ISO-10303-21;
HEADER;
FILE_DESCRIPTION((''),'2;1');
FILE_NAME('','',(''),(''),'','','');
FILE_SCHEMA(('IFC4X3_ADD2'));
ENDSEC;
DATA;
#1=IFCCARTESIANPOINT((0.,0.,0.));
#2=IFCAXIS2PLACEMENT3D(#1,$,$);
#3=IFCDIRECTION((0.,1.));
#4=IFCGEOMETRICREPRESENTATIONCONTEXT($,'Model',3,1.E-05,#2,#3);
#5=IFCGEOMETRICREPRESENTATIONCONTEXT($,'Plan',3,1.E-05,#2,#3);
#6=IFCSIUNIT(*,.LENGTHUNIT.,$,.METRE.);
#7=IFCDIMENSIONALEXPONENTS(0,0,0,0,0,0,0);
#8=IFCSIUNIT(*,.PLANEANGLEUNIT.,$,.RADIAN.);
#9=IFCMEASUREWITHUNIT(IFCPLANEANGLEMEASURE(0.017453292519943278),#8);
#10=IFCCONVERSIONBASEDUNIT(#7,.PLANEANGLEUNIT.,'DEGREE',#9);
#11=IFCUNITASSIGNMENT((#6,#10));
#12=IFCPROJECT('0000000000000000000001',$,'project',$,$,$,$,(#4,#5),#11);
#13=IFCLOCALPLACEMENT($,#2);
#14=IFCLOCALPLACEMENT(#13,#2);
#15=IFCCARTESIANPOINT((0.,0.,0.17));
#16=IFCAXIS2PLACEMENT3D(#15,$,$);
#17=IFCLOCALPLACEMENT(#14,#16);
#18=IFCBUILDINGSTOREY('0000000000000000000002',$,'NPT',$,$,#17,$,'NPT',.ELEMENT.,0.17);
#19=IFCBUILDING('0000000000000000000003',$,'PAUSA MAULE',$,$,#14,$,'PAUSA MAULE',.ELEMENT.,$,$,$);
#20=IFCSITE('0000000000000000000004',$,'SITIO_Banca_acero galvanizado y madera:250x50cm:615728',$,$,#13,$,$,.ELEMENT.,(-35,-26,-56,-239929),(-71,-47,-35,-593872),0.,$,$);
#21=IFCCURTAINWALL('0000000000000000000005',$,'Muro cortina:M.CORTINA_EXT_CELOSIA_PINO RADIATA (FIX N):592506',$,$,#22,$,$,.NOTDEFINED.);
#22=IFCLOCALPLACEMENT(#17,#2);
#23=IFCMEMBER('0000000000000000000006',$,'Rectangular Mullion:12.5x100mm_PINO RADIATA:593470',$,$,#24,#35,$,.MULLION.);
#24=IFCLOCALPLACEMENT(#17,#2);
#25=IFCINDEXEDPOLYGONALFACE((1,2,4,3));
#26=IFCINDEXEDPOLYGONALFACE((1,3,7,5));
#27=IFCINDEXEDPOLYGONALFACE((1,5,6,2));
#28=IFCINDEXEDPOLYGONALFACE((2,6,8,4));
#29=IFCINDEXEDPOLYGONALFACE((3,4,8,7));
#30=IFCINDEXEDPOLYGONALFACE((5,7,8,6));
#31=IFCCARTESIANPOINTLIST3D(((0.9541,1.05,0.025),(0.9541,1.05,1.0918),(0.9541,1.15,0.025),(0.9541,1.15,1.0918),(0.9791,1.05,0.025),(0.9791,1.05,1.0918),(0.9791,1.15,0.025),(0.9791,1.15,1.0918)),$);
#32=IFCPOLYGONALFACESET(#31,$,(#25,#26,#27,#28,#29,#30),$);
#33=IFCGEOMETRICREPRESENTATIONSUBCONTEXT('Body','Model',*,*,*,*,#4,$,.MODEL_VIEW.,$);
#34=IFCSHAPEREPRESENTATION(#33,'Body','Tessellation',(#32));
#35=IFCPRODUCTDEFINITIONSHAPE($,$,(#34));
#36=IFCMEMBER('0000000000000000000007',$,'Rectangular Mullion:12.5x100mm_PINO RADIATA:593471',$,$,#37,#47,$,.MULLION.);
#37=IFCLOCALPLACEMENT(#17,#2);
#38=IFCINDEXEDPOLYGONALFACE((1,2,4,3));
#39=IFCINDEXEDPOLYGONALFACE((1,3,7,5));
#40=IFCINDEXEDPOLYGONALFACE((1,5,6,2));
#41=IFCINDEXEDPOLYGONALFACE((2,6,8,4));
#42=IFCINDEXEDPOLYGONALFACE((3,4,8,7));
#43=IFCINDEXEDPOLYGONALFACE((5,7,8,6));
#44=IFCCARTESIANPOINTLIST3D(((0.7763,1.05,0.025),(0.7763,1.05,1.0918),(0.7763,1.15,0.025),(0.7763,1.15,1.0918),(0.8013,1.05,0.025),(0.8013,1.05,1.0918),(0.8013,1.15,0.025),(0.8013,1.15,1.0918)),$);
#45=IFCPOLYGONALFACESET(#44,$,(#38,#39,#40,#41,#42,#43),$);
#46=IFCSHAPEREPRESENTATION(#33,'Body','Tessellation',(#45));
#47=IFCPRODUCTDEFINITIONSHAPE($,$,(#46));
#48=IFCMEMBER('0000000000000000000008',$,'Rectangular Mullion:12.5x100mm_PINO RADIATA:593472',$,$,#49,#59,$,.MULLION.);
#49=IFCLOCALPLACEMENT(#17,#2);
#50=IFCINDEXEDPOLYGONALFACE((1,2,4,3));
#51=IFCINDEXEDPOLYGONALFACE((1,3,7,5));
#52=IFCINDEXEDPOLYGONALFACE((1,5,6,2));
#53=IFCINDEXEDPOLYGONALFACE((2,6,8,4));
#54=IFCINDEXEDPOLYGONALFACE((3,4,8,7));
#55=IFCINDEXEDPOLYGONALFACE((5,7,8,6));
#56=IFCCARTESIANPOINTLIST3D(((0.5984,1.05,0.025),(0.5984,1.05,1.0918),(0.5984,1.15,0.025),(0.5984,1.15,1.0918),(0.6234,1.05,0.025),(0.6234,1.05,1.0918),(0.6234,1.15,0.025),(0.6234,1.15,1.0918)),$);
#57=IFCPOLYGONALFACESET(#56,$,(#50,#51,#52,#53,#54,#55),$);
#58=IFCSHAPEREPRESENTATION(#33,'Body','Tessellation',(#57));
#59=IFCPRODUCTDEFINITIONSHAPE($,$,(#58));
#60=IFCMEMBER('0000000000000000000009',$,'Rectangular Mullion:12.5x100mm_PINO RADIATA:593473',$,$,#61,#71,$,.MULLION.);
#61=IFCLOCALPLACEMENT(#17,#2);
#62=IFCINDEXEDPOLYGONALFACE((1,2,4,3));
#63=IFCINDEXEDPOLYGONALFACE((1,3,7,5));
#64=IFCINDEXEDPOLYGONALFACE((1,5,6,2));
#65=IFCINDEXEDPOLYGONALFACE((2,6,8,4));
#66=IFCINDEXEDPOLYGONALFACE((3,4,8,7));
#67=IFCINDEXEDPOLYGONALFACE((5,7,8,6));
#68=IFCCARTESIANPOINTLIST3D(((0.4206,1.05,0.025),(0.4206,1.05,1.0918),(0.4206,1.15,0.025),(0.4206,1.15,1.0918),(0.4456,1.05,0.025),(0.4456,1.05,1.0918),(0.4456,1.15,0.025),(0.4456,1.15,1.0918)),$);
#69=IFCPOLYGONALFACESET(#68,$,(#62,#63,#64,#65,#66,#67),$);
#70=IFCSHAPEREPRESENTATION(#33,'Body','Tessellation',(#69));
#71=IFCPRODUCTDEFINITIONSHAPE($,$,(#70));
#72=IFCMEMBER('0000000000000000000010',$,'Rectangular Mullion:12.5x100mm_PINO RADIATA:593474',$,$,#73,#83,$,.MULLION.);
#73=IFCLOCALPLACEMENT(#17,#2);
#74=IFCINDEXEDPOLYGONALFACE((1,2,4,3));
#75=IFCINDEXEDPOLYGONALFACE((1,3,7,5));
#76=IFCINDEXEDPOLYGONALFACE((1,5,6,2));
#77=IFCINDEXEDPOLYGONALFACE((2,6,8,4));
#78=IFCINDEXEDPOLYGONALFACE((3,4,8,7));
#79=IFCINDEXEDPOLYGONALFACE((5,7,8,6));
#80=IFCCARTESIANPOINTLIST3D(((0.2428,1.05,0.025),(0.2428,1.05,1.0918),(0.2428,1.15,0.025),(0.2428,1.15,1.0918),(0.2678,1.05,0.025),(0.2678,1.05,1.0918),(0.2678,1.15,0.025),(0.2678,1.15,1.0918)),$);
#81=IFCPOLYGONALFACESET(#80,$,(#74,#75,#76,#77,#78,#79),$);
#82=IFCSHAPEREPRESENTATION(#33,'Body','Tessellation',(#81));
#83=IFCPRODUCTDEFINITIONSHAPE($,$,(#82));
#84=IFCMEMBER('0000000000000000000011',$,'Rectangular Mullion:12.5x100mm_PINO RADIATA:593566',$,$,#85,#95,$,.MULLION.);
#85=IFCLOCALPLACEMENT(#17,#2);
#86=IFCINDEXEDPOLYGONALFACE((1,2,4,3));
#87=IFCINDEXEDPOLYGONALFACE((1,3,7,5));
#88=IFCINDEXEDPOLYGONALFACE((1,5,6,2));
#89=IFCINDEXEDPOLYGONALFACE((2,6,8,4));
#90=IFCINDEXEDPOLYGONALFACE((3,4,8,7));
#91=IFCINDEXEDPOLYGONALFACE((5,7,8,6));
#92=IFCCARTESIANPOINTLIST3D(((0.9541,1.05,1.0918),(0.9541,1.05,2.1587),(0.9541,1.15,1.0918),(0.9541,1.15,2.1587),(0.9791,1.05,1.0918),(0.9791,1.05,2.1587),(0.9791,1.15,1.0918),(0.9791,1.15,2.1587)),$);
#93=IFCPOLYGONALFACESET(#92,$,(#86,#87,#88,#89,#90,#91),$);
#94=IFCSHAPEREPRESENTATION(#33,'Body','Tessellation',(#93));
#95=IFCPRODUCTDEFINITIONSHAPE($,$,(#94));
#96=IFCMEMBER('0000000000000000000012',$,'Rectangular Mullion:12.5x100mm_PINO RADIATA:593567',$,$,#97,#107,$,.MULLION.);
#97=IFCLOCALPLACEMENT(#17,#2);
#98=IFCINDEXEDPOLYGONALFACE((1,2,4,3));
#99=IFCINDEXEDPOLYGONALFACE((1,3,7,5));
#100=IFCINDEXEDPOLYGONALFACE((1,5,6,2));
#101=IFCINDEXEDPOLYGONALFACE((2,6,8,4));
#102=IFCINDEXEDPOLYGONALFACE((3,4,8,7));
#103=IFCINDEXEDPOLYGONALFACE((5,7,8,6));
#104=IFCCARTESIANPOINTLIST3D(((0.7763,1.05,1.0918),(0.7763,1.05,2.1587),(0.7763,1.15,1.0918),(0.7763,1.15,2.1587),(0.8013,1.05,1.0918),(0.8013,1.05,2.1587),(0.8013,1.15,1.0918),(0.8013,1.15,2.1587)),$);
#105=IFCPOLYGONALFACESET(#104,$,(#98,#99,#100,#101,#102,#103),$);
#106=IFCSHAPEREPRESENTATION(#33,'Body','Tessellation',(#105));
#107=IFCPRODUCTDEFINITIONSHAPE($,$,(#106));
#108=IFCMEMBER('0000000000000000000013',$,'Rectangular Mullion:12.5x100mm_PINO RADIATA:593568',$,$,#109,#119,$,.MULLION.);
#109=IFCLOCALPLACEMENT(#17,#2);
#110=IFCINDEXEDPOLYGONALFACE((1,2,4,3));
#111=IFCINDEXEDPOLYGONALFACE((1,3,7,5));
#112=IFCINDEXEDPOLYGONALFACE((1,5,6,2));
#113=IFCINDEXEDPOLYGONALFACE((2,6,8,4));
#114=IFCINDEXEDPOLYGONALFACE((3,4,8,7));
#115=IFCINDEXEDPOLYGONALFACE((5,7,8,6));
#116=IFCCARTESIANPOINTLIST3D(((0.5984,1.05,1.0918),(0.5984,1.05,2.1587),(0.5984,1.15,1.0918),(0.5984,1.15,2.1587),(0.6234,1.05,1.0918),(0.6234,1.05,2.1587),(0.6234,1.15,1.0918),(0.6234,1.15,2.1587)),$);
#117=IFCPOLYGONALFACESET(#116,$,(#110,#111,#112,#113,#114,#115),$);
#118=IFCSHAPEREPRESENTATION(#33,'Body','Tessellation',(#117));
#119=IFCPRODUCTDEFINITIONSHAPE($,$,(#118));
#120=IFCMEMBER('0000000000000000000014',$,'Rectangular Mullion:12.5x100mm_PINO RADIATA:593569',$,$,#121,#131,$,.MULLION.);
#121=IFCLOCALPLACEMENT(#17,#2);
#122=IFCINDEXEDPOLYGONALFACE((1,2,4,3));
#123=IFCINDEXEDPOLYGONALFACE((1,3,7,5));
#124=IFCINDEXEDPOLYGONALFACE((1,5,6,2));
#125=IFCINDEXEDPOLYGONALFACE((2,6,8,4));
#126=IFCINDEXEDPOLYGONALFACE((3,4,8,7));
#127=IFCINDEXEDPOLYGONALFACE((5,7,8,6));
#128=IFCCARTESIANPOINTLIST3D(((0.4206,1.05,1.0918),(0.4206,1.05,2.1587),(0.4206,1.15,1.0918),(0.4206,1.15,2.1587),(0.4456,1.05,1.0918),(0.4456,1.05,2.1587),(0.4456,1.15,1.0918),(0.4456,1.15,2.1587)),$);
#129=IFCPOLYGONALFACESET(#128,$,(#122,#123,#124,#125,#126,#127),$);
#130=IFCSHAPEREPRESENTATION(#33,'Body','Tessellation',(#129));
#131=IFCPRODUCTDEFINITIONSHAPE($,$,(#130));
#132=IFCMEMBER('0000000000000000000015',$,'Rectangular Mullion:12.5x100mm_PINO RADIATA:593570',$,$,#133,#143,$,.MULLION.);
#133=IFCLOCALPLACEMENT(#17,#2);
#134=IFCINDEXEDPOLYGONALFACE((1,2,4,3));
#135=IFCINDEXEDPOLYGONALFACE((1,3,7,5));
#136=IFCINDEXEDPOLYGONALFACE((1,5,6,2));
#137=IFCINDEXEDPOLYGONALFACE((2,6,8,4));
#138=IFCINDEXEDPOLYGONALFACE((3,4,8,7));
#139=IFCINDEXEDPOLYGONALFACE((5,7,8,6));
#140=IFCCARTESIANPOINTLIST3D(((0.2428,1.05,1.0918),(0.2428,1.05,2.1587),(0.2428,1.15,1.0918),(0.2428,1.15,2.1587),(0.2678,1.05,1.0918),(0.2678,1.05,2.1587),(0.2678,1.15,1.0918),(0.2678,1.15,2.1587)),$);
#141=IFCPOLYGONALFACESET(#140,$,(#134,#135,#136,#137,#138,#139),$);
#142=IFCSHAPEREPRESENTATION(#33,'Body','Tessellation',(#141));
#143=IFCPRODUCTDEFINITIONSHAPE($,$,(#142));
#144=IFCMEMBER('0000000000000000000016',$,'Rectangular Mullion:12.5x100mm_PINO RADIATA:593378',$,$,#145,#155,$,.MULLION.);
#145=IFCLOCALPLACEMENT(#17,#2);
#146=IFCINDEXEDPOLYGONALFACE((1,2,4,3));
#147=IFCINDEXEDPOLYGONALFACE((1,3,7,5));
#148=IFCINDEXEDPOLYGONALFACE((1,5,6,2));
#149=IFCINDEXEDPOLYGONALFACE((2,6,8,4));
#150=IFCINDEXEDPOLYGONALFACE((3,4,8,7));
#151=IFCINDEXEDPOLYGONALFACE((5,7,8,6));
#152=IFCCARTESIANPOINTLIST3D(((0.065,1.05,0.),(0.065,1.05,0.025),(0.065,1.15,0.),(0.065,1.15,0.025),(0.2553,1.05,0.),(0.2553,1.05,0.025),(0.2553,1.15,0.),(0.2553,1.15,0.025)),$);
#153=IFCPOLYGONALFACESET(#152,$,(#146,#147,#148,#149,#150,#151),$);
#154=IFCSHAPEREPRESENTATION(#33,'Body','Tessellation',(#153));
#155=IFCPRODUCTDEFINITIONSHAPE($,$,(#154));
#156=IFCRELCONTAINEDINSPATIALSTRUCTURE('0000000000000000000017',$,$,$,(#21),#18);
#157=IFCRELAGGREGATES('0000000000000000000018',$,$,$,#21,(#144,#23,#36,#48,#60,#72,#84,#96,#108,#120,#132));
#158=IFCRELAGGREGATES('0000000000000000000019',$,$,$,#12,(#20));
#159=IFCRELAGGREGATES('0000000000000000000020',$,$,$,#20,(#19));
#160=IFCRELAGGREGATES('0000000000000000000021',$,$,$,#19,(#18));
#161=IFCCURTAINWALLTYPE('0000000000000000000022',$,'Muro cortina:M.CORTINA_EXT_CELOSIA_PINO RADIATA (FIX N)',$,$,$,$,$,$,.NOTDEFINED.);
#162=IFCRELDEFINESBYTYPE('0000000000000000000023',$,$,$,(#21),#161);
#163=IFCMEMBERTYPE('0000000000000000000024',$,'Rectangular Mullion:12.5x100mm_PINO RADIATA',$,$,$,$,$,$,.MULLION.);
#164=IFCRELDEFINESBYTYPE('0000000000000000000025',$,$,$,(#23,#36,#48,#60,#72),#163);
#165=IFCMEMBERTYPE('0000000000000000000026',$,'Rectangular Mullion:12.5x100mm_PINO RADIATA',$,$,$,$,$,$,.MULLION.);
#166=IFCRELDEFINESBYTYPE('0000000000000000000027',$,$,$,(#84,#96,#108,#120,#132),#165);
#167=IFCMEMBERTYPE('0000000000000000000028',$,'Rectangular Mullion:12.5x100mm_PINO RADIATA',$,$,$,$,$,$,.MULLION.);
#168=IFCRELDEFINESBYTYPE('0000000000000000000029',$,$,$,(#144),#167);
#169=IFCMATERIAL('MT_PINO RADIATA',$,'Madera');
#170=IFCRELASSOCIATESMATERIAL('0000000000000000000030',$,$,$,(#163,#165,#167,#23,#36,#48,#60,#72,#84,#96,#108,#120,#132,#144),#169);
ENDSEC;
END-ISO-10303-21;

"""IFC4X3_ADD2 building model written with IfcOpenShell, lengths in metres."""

from ifc_helpers import new_model, entity, si_unit, converted_unit, direction, frame, frame_2d, origin, origin_2d_with_axis, place, context, subcontext, project, spatial, rectangle, extrude, source, transform, mapped, material, material_profile, profile_set, profile_usage, type_object, type_shapes, element, aggregate, save


model = new_model("IFC4X3_ADD2")

# Units and contexts
model_context = context("Model", 3, precision=1e-05, world=origin(), true_north=direction((0.0, 1.0)))
plan_context = context("Plan", 3, precision=1e-05, world=origin(), true_north=direction((0.0, 1.0)))
body_context = subcontext(model_context, "Body", "Model", "MODEL_VIEW")
ifc_project = project(units=[si_unit("LENGTHUNIT", "METRE"), converted_unit("PLANEANGLEUNIT", "DEGREE", entity("IfcPlaneAngleMeasure", 0.017453292519943278), si_unit("PLANEANGLEUNIT", "RADIAN"), dimensions=[0, 0, 0, 0, 0, 0, 0])], contexts=[model_context, plan_context])

# Site, building, storey
site_placement = place(None, origin())
site = spatial("IfcSite", under=ifc_project, at=site_placement, Name="SITIO_Banca_acero galvanizado y madera:250x50cm:615728", CompositionType="ELEMENT", RefLatitude=(-35, -26, -56, -239929), RefLongitude=(-71, -47, -35, -593872), RefElevation=0.0)
building_placement = place(site_placement, origin())
building = spatial("IfcBuilding", under=site, at=building_placement, Name="PAUSA MAULE", LongName="PAUSA MAULE", CompositionType="ELEMENT")
storey_placement = place(building_placement, frame((0.0, 0.0, 0.17)))
storey = spatial("IfcBuildingStorey", under=building, at=storey_placement, Name="NPT", LongName="NPT", CompositionType="ELEMENT", Elevation=0.17)

# Curtain wall, members
curtain_wall_type = type_object("IfcCurtainWallType", Name="Muro cortina:M.CORTINA_EXT_CELOSIA_PINO RADIATA (FIX N)", PredefinedType="NOTDEFINED")
curtain_wall_placement = place(storey_placement, frame((0.0, 0.0, -0.17)))
curtain_wall = element("IfcCurtainWall", 1, at=curtain_wall_placement, inside=storey, type_object=curtain_wall_type, Name="Muro cortina:M.CORTINA_EXT_CELOSIA_PINO RADIATA (FIX N):592506", PredefinedType="NOTDEFINED")
ifc_material_1 = material(Name="MT_PINO RADIATA", Category="Madera")
ifc_material_profile = material_profile(ifc_material_1, rectangle(XDim=0.025, YDim=0.1, at=frame_2d((0.0, 0.0), x_axis=(1.0, 0.0))), Name="12.5x100mm_PINO RADIATA")
ifc_profile_set = profile_set([ifc_material_profile], Name="12.5x100mm_PINO RADIATA")
ifc_profile_usage = profile_usage(ifc_profile_set)
member_type_1 = type_object("IfcMemberType", Name="Rectangular Mullion:12.5x100mm_PINO RADIATA", PredefinedType="MULLION", material=ifc_profile_set)
shared_shape_1 = source(origin(), body_context, "Body", "SweptSolid", [
    extrude(rectangle(XDim=0.025, YDim=0.1, at=origin_2d_with_axis()), frame((0.0, 0.0, -1.0668), z_axis=(0.0, 0.0, 1.0), x_axis=(-1.0, 0.0, 0.0)), (0.0, 0.0, 1.0), 1.0668),
])
type_shapes(member_type_1, [shared_shape_1])
member_1_placement = place(curtain_wall_placement, frame((0.9666, 1.1, 0.195), z_axis=(0.0, 0.0, -1.0), x_axis=(-1.0, 0.0, 0.0)))
member_1 = element("IfcMember", 2, at=member_1_placement, type_object=member_type_1, material=ifc_profile_usage, Name="Rectangular Mullion:12.5x100mm_PINO RADIATA:593470", PredefinedType="MULLION", context=body_context, shape_type="MappedRepresentation", body=[
    mapped(shared_shape_1, transform((0.0, 0.0, 0.0), scale=1.0)),
])
member_2_placement = place(curtain_wall_placement, frame((0.7888, 1.1, 0.195), z_axis=(0.0, 0.0, -1.0), x_axis=(-1.0, 0.0, 0.0)))
member_2 = element("IfcMember", 3, at=member_2_placement, type_object=member_type_1, material=ifc_profile_usage, Name="Rectangular Mullion:12.5x100mm_PINO RADIATA:593471", PredefinedType="MULLION", context=body_context, shape_type="MappedRepresentation", body=[
    mapped(shared_shape_1, transform((0.0, 0.0, 0.0), scale=1.0)),
])
member_3_placement = place(curtain_wall_placement, frame((0.6109, 1.1, 0.195), z_axis=(0.0, 0.0, -1.0), x_axis=(-1.0, 0.0, 0.0)))
member_3 = element("IfcMember", 4, at=member_3_placement, type_object=member_type_1, material=ifc_profile_usage, Name="Rectangular Mullion:12.5x100mm_PINO RADIATA:593472", PredefinedType="MULLION", context=body_context, shape_type="MappedRepresentation", body=[
    mapped(shared_shape_1, transform((0.0, 0.0, 0.0), scale=1.0)),
])
member_4_placement = place(curtain_wall_placement, frame((0.4331, 1.1, 0.195), z_axis=(0.0, 0.0, -1.0), x_axis=(-1.0, 0.0, 0.0)))
member_4 = element("IfcMember", 5, at=member_4_placement, type_object=member_type_1, material=ifc_profile_usage, Name="Rectangular Mullion:12.5x100mm_PINO RADIATA:593473", PredefinedType="MULLION", context=body_context, shape_type="MappedRepresentation", body=[
    mapped(shared_shape_1, transform((0.0, 0.0, 0.0), scale=1.0)),
])
member_5_placement = place(curtain_wall_placement, frame((0.2553, 1.1, 0.195), z_axis=(0.0, 0.0, -1.0), x_axis=(-1.0, 0.0, 0.0)))
member_5 = element("IfcMember", 6, at=member_5_placement, type_object=member_type_1, material=ifc_profile_usage, Name="Rectangular Mullion:12.5x100mm_PINO RADIATA:593474", PredefinedType="MULLION", context=body_context, shape_type="MappedRepresentation", body=[
    mapped(shared_shape_1, transform((0.0, 0.0, 0.0), scale=1.0)),
])
member_type_2 = type_object("IfcMemberType", Name="Rectangular Mullion:12.5x100mm_PINO RADIATA", PredefinedType="MULLION", material=ifc_profile_set)
shared_shape_2 = source(origin(), body_context, "Body", "SweptSolid", [
    extrude(rectangle(XDim=0.025, YDim=0.1, at=origin_2d_with_axis()), frame((0.0, 0.0, -1.0668), z_axis=(0.0, 0.0, 1.0), x_axis=(-1.0, 0.0, 0.0)), (0.0, 0.0, 1.0), 1.0668),
])
type_shapes(member_type_2, [shared_shape_2])
member_6_placement = place(curtain_wall_placement, frame((0.9666, 1.1, 1.2618), z_axis=(0.0, 0.0, -1.0), x_axis=(-1.0, 0.0, 0.0)))
member_6 = element("IfcMember", 7, at=member_6_placement, type_object=member_type_2, material=ifc_profile_usage, Name="Rectangular Mullion:12.5x100mm_PINO RADIATA:593566", PredefinedType="MULLION", context=body_context, shape_type="MappedRepresentation", body=[
    mapped(shared_shape_2, transform((0.0, 0.0, 0.0), scale=1.0)),
])
member_7_placement = place(curtain_wall_placement, frame((0.7888, 1.1, 1.2618), z_axis=(0.0, 0.0, -1.0), x_axis=(-1.0, 0.0, 0.0)))
member_7 = element("IfcMember", 8, at=member_7_placement, type_object=member_type_2, material=ifc_profile_usage, Name="Rectangular Mullion:12.5x100mm_PINO RADIATA:593567", PredefinedType="MULLION", context=body_context, shape_type="MappedRepresentation", body=[
    mapped(shared_shape_2, transform((0.0, 0.0, 0.0), scale=1.0)),
])
member_8_placement = place(curtain_wall_placement, frame((0.6109, 1.1, 1.2618), z_axis=(0.0, 0.0, -1.0), x_axis=(-1.0, 0.0, 0.0)))
member_8 = element("IfcMember", 9, at=member_8_placement, type_object=member_type_2, material=ifc_profile_usage, Name="Rectangular Mullion:12.5x100mm_PINO RADIATA:593568", PredefinedType="MULLION", context=body_context, shape_type="MappedRepresentation", body=[
    mapped(shared_shape_2, transform((0.0, 0.0, 0.0), scale=1.0)),
])
member_9_placement = place(curtain_wall_placement, frame((0.4331, 1.1, 1.2618), z_axis=(0.0, 0.0, -1.0), x_axis=(-1.0, 0.0, 0.0)))
member_9 = element("IfcMember", 10, at=member_9_placement, type_object=member_type_2, material=ifc_profile_usage, Name="Rectangular Mullion:12.5x100mm_PINO RADIATA:593569", PredefinedType="MULLION", context=body_context, shape_type="MappedRepresentation", body=[
    mapped(shared_shape_2, transform((0.0, 0.0, 0.0), scale=1.0)),
])
member_10_placement = place(curtain_wall_placement, frame((0.2553, 1.1, 1.2618), z_axis=(0.0, 0.0, -1.0), x_axis=(-1.0, 0.0, 0.0)))
member_10 = element("IfcMember", 11, at=member_10_placement, type_object=member_type_2, material=ifc_profile_usage, Name="Rectangular Mullion:12.5x100mm_PINO RADIATA:593570", PredefinedType="MULLION", context=body_context, shape_type="MappedRepresentation", body=[
    mapped(shared_shape_2, transform((0.0, 0.0, 0.0), scale=1.0)),
])
member_type_3 = type_object("IfcMemberType", Name="Rectangular Mullion:12.5x100mm_PINO RADIATA", PredefinedType="MULLION", material=ifc_profile_set)
shared_shape_3 = source(origin(), body_context, "Body", "SweptSolid", [
    extrude(rectangle(XDim=0.025, YDim=0.1, at=frame_2d((0.0, 0.0), x_axis=(1.0, 0.0))), frame((-0.0125, 0.0, -0.1903), z_axis=(0.0, 0.0, 1.0), x_axis=(-1.0, 0.0, 0.0)), (0.0, 0.0, 1.0), 0.1903),
])
type_shapes(member_type_3, [shared_shape_3])
member_11_placement = place(curtain_wall_placement, frame((0.2553, 1.1, 0.17), z_axis=(1.0, 0.0, 0.0), x_axis=(0.0, 0.0, -1.0)))
member_11 = element("IfcMember", 12, at=member_11_placement, type_object=member_type_3, material=ifc_profile_usage, Name="Rectangular Mullion:12.5x100mm_PINO RADIATA:593378", PredefinedType="MULLION", context=body_context, shape_type="MappedRepresentation", body=[
    mapped(shared_shape_3, transform((0.0, 0.0, 0.0), scale=1.0)),
])
aggregate(curtain_wall, [member_11, member_1, member_2, member_3, member_4, member_5, member_6, member_7, member_8, member_9, member_10])

save(model, "model.ifc")
